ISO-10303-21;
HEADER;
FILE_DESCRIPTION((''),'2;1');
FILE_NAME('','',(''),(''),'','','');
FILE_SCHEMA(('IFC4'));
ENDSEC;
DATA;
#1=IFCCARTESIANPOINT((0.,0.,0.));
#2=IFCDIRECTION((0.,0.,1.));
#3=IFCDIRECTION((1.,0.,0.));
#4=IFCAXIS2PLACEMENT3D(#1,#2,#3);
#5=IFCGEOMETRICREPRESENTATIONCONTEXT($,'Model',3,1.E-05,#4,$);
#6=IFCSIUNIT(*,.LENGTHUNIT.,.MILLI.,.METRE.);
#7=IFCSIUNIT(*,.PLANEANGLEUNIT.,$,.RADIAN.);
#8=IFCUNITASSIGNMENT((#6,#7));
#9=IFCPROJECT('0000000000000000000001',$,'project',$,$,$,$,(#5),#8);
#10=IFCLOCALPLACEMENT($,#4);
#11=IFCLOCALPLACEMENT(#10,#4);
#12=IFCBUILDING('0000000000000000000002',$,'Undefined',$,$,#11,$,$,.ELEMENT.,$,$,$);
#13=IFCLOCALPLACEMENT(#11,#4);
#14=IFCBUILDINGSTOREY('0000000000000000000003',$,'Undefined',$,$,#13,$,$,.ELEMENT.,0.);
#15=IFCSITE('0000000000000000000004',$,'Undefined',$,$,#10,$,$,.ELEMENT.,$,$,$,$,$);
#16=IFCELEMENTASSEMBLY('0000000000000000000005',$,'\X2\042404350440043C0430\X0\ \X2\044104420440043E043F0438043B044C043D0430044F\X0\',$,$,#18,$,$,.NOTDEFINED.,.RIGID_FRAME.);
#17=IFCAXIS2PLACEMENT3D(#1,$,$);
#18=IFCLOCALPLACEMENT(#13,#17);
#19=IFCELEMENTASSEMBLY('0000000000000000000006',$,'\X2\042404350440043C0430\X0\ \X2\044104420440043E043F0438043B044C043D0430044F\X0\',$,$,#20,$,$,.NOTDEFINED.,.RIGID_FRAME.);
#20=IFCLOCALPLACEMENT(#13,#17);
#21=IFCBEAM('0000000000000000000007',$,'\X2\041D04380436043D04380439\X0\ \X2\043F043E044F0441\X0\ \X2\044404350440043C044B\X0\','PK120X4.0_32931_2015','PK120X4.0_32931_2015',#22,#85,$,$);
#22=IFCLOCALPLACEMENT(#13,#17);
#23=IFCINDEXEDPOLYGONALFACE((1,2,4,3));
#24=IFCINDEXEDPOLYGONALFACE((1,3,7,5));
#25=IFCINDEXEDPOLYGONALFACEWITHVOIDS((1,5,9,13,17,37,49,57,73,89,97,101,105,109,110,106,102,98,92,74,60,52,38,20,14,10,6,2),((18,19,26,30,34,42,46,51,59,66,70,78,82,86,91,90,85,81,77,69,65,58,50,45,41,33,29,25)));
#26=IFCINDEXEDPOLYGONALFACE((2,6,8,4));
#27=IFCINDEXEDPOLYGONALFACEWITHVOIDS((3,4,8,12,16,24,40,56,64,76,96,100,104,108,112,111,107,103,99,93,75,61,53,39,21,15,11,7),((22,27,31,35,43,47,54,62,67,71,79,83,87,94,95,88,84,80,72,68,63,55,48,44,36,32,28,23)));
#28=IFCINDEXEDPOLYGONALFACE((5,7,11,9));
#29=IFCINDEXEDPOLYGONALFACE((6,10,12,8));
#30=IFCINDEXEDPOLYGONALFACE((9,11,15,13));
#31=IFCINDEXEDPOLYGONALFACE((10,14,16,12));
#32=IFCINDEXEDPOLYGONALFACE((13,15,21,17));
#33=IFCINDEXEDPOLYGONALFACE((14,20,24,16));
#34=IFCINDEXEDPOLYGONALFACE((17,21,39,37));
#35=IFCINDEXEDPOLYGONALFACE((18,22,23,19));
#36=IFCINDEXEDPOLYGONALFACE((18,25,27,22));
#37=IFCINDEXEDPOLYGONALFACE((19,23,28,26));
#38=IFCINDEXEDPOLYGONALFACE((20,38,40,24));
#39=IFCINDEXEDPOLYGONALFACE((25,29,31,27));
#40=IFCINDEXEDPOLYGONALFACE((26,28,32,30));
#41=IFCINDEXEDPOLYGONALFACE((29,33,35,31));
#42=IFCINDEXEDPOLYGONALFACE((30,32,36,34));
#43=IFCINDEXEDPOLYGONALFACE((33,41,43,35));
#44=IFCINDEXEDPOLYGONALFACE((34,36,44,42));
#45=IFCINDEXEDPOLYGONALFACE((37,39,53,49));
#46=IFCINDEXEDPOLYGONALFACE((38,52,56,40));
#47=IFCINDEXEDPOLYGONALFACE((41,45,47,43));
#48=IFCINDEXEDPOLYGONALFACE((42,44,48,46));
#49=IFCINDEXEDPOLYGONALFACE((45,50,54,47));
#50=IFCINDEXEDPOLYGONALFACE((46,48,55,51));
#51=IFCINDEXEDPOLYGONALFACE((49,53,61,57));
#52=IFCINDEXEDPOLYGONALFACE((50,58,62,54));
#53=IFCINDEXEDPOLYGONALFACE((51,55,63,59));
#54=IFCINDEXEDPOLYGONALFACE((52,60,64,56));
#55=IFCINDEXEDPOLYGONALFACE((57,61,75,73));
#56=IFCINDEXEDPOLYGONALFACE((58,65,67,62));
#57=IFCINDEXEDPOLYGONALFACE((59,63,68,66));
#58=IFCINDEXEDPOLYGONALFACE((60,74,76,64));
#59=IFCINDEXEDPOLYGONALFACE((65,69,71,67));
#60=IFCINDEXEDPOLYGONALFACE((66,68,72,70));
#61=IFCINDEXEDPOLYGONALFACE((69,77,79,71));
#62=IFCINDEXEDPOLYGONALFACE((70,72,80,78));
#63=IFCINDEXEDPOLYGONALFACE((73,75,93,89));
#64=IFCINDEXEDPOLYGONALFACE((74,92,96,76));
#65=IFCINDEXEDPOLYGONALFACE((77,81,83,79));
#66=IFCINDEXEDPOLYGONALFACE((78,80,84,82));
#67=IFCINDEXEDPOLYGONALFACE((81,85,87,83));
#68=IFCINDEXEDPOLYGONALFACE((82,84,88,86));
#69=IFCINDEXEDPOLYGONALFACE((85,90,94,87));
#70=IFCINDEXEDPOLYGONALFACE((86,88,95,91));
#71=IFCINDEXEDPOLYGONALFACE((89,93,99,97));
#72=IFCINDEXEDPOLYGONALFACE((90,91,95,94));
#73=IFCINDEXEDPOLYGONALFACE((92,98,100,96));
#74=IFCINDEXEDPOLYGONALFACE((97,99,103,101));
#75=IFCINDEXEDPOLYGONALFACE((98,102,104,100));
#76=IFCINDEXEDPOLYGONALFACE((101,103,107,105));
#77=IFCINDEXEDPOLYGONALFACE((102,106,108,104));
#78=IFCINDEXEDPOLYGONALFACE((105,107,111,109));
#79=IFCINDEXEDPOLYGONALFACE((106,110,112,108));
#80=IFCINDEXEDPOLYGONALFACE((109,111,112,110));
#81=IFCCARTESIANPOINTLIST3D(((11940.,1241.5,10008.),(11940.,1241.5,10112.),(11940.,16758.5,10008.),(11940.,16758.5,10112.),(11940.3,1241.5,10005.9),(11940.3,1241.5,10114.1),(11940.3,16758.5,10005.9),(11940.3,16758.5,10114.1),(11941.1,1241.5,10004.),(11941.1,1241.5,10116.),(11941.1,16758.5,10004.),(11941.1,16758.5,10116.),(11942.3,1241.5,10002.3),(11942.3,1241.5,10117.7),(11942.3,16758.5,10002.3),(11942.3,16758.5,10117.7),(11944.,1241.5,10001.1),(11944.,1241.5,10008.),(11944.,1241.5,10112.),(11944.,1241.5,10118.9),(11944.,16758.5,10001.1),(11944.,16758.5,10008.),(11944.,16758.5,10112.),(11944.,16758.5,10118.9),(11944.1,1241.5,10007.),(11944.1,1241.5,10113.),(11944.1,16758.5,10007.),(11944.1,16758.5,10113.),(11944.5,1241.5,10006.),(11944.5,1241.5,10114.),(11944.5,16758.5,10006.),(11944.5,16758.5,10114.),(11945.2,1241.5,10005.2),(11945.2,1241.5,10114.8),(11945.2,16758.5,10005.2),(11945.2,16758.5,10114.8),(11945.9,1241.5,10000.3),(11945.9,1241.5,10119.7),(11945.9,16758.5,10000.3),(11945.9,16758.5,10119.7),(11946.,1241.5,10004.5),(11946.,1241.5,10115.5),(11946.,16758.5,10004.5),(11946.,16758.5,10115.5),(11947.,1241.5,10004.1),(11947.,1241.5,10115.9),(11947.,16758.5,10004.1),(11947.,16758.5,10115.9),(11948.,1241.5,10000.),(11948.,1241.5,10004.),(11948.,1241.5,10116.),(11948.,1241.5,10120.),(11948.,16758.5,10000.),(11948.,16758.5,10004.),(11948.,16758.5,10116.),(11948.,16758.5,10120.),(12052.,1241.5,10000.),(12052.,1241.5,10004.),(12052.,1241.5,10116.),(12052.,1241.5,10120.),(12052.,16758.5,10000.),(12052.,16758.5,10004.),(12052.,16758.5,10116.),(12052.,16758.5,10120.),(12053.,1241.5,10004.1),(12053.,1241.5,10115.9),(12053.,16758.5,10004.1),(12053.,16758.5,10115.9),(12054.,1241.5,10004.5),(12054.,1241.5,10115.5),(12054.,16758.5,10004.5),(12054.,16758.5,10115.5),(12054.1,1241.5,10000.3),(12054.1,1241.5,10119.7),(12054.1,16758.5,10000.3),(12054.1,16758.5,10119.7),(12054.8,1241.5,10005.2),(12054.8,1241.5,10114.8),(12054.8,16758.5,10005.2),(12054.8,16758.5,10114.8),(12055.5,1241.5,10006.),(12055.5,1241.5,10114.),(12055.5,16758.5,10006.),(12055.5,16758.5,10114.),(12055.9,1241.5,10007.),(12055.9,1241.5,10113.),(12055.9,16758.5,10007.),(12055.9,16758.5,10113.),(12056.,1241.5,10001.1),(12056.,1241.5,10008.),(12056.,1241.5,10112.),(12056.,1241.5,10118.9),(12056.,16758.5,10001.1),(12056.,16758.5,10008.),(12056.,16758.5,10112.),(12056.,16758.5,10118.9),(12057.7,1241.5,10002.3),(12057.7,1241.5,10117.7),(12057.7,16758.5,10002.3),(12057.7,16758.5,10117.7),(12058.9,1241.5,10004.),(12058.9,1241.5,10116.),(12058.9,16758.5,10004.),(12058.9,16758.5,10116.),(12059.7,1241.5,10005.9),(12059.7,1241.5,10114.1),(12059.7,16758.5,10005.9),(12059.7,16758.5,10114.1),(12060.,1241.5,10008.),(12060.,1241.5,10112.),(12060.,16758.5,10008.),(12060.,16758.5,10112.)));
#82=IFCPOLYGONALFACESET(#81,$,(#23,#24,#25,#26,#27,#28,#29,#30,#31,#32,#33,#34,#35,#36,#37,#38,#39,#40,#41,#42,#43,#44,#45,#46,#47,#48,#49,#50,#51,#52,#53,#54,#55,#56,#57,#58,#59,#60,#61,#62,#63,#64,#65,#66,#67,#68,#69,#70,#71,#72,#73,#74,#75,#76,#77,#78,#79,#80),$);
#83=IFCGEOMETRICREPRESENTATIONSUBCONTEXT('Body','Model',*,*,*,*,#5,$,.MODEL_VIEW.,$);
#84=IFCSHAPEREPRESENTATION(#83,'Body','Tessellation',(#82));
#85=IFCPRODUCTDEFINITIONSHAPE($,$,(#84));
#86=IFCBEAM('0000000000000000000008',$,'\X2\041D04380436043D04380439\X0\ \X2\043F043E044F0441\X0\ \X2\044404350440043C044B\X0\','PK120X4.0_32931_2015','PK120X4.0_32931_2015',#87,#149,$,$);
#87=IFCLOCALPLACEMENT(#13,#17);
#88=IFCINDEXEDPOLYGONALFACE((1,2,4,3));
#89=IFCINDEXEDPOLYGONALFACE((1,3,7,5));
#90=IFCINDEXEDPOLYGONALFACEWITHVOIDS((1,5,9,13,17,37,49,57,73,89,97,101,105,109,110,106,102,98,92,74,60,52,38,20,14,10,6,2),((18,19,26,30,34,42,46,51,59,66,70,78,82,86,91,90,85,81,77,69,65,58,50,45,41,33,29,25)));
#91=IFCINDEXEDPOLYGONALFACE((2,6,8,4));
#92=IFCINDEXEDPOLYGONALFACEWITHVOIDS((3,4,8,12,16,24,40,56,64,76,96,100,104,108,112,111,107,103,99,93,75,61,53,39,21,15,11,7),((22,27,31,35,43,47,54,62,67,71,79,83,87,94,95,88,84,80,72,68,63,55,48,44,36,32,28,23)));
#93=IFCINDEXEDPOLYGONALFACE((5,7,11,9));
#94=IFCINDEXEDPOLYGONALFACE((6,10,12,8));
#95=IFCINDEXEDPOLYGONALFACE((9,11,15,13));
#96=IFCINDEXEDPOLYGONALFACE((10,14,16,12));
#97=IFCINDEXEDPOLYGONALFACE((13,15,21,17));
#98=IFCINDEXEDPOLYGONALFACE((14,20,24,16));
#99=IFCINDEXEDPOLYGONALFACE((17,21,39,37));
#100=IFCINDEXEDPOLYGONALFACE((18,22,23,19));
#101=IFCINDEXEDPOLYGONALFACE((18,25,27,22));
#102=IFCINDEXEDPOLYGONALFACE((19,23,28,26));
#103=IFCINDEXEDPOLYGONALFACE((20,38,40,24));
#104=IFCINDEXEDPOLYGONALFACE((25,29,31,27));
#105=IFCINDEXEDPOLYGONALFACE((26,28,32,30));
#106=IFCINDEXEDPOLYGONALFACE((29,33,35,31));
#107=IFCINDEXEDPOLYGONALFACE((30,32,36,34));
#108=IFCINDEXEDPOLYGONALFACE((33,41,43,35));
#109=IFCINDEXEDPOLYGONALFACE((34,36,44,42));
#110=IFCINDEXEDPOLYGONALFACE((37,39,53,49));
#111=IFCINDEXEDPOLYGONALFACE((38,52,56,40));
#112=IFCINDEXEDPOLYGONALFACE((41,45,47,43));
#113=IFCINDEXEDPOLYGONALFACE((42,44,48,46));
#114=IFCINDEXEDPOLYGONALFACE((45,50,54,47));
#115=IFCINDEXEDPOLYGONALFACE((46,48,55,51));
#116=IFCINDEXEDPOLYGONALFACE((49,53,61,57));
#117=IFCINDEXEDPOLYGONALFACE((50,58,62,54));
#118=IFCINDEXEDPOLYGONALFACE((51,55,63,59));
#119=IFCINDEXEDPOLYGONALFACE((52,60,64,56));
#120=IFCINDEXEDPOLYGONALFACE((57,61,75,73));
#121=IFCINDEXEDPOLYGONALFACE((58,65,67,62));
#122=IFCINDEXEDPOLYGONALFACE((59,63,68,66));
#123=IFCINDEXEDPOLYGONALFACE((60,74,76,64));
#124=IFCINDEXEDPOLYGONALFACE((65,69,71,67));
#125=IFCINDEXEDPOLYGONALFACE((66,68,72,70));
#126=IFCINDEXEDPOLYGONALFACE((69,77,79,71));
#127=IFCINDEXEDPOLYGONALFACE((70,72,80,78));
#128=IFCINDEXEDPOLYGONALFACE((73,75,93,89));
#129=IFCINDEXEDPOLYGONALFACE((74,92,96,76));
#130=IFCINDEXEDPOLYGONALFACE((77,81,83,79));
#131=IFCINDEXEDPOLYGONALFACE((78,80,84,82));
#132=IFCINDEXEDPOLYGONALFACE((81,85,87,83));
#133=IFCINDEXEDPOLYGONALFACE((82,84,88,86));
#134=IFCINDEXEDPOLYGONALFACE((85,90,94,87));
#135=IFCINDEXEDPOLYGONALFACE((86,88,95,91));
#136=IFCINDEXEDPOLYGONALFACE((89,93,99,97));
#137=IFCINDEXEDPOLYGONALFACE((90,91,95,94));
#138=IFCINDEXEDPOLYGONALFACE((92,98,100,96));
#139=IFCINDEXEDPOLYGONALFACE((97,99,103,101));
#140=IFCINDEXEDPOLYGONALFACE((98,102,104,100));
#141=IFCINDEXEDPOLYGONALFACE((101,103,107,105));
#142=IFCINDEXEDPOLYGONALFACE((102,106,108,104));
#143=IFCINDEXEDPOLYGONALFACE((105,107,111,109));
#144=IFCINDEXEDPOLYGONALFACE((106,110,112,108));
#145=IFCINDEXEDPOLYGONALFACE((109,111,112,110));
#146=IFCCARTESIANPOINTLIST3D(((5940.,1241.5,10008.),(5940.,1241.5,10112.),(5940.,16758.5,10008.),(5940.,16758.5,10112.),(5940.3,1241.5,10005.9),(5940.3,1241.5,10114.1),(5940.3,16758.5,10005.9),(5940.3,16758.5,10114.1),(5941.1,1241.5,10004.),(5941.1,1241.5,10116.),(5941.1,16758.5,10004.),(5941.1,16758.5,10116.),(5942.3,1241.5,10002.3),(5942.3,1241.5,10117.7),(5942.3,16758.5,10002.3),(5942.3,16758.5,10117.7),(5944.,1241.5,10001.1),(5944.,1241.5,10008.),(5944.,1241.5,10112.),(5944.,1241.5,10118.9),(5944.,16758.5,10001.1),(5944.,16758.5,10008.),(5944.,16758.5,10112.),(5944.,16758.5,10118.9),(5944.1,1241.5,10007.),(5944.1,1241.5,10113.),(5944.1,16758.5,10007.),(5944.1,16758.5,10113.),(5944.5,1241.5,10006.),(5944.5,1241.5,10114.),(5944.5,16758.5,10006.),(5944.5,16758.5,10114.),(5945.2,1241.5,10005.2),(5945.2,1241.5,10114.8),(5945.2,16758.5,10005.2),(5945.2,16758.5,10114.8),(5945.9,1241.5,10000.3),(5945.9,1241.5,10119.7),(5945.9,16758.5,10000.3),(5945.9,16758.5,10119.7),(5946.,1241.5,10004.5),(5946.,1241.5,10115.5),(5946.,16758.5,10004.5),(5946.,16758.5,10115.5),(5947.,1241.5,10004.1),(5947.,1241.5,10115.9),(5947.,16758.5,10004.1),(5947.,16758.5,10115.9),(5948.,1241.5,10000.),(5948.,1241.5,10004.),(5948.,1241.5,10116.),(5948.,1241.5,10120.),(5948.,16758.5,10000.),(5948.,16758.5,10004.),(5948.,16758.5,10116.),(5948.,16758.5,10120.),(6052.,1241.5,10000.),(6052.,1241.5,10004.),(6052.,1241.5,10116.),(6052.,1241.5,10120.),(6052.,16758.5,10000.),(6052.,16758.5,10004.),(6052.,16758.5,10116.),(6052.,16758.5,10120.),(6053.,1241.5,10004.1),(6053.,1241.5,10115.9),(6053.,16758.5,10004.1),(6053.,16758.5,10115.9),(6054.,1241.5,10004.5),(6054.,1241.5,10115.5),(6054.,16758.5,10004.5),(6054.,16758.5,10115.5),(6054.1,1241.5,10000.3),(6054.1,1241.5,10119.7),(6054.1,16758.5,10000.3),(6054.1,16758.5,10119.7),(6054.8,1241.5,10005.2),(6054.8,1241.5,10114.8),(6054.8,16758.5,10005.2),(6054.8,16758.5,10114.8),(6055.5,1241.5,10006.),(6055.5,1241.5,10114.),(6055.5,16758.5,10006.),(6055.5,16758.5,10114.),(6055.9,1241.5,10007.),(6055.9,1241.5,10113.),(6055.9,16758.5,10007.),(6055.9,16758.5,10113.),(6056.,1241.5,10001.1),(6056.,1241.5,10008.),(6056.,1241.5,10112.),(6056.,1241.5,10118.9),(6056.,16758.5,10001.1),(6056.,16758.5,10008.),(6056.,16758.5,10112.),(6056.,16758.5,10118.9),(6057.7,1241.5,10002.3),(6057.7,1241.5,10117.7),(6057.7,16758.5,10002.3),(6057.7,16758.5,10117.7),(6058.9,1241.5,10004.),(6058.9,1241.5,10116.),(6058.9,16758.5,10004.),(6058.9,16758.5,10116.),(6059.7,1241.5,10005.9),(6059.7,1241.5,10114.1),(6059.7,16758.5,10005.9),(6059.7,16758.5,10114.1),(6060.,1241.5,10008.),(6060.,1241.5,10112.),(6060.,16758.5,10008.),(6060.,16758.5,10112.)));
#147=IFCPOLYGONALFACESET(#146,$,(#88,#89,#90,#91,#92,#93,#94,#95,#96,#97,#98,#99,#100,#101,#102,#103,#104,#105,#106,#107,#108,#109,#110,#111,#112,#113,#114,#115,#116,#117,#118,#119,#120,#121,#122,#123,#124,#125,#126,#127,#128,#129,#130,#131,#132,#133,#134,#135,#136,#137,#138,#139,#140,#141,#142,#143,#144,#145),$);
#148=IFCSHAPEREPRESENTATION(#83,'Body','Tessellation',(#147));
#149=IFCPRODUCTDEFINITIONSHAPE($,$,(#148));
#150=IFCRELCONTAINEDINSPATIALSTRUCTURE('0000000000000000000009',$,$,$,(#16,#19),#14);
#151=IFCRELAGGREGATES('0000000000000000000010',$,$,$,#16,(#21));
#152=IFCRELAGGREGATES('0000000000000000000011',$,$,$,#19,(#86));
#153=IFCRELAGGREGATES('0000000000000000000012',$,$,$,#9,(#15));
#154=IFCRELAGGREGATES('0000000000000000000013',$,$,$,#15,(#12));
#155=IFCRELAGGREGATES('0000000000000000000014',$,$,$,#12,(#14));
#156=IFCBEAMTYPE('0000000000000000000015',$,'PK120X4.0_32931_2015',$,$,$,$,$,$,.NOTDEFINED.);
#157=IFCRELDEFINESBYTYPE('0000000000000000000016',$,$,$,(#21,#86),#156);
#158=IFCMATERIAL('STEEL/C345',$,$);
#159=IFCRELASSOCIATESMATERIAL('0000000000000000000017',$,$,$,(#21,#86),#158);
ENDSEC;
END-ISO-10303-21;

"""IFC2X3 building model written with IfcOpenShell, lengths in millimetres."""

from ifc_helpers import new_model, si_unit, frame, origin_with_axes, origin_2d_with_axis, place, context, subcontext, project, spatial, hollow_rectangle, extrude, material, type_object, element, aggregate, save


model = new_model("IFC2X3")

# Units and contexts
model_context = context("Model", 3, precision=1e-05, world=origin_with_axes())
body_context = subcontext(model_context, "Body", "Model", "MODEL_VIEW")
ifc_project = project(units=[si_unit("LENGTHUNIT", "METRE", prefix="MILLI"), si_unit("PLANEANGLEUNIT", "RADIAN")], contexts=[model_context])

# Site, building, storey
site_placement = place(None, origin_with_axes())
site = spatial("IfcSite", under=ifc_project, at=site_placement, Name="Undefined", CompositionType="ELEMENT")
building_placement = place(site_placement, origin_with_axes())
building = spatial("IfcBuilding", under=site, at=building_placement, Name="Undefined", CompositionType="ELEMENT")
storey_placement = place(building_placement, origin_with_axes())
storey = spatial("IfcBuildingStorey", under=building, at=storey_placement, Name="Undefined", CompositionType="ELEMENT", Elevation=0.0)

# Shared definitions
ifc_material_1 = material(Name="STEEL/C345")

# Element assembly
assembly_1_placement = place(storey_placement, origin_with_axes())
assembly_1 = element("IfcElementAssembly", 1, at=assembly_1_placement, inside=storey, Name="Ферма стропильная", AssemblyPlace="NOTDEFINED", PredefinedType="RIGID_FRAME")

# Element assembly
assembly_2_placement = place(storey_placement, origin_with_axes())
assembly_2 = element("IfcElementAssembly", 2, at=assembly_2_placement, inside=storey, Name="Ферма стропильная", AssemblyPlace="NOTDEFINED", PredefinedType="RIGID_FRAME")

# Beams
beam_type_1 = type_object("IfcBeamType", Name="PK120X4.0_32931_2015", PredefinedType="NOTDEFINED")
beam_1_placement = place(assembly_1_placement, frame((12000.0, 1241.5, 10060.0), z_axis=(0.0, 0.0, 1.0), x_axis=(0.0, 1.0, 0.0)))
beam_1 = element("IfcBeam", 3, at=beam_1_placement, type_object=beam_type_1, material=ifc_material_1, Name="Нижний пояс фермы", Description="PK120X4.0_32931_2015", ObjectType="PK120X4.0_32931_2015", context=body_context, shape_type="SweptSolid", body=[
    extrude(hollow_rectangle(XDim=120.0, YDim=120.0, WallThickness=4.0, InnerFilletRadius=4.0, OuterFilletRadius=8.0, at=origin_2d_with_axis()), frame((15517.0, 0.0, 0.0), z_axis=(-1.0, 0.0, 0.0), x_axis=(0.0, -1.0, 0.0)), (0.0, 0.0, 1.0), 15517.0),
])
aggregate(assembly_1, [beam_1])
beam_2_placement = place(assembly_2_placement, frame((6000.0, 1241.5, 10060.0), z_axis=(0.0, 0.0, 1.0), x_axis=(0.0, 1.0, 0.0)))
beam_2 = element("IfcBeam", 4, at=beam_2_placement, type_object=beam_type_1, material=ifc_material_1, Name="Нижний пояс фермы", Description="PK120X4.0_32931_2015", ObjectType="PK120X4.0_32931_2015", context=body_context, shape_type="SweptSolid", body=[
    extrude(hollow_rectangle(XDim=120.0, YDim=120.0, WallThickness=4.0, InnerFilletRadius=4.0, OuterFilletRadius=8.0, at=origin_2d_with_axis()), frame((15517.0, 0.0, 0.0), z_axis=(-1.0, 0.0, 0.0), x_axis=(0.0, -1.0, 0.0)), (0.0, 0.0, 1.0), 15517.0),
])
aggregate(assembly_2, [beam_2])

save(model, "model.ifc")
